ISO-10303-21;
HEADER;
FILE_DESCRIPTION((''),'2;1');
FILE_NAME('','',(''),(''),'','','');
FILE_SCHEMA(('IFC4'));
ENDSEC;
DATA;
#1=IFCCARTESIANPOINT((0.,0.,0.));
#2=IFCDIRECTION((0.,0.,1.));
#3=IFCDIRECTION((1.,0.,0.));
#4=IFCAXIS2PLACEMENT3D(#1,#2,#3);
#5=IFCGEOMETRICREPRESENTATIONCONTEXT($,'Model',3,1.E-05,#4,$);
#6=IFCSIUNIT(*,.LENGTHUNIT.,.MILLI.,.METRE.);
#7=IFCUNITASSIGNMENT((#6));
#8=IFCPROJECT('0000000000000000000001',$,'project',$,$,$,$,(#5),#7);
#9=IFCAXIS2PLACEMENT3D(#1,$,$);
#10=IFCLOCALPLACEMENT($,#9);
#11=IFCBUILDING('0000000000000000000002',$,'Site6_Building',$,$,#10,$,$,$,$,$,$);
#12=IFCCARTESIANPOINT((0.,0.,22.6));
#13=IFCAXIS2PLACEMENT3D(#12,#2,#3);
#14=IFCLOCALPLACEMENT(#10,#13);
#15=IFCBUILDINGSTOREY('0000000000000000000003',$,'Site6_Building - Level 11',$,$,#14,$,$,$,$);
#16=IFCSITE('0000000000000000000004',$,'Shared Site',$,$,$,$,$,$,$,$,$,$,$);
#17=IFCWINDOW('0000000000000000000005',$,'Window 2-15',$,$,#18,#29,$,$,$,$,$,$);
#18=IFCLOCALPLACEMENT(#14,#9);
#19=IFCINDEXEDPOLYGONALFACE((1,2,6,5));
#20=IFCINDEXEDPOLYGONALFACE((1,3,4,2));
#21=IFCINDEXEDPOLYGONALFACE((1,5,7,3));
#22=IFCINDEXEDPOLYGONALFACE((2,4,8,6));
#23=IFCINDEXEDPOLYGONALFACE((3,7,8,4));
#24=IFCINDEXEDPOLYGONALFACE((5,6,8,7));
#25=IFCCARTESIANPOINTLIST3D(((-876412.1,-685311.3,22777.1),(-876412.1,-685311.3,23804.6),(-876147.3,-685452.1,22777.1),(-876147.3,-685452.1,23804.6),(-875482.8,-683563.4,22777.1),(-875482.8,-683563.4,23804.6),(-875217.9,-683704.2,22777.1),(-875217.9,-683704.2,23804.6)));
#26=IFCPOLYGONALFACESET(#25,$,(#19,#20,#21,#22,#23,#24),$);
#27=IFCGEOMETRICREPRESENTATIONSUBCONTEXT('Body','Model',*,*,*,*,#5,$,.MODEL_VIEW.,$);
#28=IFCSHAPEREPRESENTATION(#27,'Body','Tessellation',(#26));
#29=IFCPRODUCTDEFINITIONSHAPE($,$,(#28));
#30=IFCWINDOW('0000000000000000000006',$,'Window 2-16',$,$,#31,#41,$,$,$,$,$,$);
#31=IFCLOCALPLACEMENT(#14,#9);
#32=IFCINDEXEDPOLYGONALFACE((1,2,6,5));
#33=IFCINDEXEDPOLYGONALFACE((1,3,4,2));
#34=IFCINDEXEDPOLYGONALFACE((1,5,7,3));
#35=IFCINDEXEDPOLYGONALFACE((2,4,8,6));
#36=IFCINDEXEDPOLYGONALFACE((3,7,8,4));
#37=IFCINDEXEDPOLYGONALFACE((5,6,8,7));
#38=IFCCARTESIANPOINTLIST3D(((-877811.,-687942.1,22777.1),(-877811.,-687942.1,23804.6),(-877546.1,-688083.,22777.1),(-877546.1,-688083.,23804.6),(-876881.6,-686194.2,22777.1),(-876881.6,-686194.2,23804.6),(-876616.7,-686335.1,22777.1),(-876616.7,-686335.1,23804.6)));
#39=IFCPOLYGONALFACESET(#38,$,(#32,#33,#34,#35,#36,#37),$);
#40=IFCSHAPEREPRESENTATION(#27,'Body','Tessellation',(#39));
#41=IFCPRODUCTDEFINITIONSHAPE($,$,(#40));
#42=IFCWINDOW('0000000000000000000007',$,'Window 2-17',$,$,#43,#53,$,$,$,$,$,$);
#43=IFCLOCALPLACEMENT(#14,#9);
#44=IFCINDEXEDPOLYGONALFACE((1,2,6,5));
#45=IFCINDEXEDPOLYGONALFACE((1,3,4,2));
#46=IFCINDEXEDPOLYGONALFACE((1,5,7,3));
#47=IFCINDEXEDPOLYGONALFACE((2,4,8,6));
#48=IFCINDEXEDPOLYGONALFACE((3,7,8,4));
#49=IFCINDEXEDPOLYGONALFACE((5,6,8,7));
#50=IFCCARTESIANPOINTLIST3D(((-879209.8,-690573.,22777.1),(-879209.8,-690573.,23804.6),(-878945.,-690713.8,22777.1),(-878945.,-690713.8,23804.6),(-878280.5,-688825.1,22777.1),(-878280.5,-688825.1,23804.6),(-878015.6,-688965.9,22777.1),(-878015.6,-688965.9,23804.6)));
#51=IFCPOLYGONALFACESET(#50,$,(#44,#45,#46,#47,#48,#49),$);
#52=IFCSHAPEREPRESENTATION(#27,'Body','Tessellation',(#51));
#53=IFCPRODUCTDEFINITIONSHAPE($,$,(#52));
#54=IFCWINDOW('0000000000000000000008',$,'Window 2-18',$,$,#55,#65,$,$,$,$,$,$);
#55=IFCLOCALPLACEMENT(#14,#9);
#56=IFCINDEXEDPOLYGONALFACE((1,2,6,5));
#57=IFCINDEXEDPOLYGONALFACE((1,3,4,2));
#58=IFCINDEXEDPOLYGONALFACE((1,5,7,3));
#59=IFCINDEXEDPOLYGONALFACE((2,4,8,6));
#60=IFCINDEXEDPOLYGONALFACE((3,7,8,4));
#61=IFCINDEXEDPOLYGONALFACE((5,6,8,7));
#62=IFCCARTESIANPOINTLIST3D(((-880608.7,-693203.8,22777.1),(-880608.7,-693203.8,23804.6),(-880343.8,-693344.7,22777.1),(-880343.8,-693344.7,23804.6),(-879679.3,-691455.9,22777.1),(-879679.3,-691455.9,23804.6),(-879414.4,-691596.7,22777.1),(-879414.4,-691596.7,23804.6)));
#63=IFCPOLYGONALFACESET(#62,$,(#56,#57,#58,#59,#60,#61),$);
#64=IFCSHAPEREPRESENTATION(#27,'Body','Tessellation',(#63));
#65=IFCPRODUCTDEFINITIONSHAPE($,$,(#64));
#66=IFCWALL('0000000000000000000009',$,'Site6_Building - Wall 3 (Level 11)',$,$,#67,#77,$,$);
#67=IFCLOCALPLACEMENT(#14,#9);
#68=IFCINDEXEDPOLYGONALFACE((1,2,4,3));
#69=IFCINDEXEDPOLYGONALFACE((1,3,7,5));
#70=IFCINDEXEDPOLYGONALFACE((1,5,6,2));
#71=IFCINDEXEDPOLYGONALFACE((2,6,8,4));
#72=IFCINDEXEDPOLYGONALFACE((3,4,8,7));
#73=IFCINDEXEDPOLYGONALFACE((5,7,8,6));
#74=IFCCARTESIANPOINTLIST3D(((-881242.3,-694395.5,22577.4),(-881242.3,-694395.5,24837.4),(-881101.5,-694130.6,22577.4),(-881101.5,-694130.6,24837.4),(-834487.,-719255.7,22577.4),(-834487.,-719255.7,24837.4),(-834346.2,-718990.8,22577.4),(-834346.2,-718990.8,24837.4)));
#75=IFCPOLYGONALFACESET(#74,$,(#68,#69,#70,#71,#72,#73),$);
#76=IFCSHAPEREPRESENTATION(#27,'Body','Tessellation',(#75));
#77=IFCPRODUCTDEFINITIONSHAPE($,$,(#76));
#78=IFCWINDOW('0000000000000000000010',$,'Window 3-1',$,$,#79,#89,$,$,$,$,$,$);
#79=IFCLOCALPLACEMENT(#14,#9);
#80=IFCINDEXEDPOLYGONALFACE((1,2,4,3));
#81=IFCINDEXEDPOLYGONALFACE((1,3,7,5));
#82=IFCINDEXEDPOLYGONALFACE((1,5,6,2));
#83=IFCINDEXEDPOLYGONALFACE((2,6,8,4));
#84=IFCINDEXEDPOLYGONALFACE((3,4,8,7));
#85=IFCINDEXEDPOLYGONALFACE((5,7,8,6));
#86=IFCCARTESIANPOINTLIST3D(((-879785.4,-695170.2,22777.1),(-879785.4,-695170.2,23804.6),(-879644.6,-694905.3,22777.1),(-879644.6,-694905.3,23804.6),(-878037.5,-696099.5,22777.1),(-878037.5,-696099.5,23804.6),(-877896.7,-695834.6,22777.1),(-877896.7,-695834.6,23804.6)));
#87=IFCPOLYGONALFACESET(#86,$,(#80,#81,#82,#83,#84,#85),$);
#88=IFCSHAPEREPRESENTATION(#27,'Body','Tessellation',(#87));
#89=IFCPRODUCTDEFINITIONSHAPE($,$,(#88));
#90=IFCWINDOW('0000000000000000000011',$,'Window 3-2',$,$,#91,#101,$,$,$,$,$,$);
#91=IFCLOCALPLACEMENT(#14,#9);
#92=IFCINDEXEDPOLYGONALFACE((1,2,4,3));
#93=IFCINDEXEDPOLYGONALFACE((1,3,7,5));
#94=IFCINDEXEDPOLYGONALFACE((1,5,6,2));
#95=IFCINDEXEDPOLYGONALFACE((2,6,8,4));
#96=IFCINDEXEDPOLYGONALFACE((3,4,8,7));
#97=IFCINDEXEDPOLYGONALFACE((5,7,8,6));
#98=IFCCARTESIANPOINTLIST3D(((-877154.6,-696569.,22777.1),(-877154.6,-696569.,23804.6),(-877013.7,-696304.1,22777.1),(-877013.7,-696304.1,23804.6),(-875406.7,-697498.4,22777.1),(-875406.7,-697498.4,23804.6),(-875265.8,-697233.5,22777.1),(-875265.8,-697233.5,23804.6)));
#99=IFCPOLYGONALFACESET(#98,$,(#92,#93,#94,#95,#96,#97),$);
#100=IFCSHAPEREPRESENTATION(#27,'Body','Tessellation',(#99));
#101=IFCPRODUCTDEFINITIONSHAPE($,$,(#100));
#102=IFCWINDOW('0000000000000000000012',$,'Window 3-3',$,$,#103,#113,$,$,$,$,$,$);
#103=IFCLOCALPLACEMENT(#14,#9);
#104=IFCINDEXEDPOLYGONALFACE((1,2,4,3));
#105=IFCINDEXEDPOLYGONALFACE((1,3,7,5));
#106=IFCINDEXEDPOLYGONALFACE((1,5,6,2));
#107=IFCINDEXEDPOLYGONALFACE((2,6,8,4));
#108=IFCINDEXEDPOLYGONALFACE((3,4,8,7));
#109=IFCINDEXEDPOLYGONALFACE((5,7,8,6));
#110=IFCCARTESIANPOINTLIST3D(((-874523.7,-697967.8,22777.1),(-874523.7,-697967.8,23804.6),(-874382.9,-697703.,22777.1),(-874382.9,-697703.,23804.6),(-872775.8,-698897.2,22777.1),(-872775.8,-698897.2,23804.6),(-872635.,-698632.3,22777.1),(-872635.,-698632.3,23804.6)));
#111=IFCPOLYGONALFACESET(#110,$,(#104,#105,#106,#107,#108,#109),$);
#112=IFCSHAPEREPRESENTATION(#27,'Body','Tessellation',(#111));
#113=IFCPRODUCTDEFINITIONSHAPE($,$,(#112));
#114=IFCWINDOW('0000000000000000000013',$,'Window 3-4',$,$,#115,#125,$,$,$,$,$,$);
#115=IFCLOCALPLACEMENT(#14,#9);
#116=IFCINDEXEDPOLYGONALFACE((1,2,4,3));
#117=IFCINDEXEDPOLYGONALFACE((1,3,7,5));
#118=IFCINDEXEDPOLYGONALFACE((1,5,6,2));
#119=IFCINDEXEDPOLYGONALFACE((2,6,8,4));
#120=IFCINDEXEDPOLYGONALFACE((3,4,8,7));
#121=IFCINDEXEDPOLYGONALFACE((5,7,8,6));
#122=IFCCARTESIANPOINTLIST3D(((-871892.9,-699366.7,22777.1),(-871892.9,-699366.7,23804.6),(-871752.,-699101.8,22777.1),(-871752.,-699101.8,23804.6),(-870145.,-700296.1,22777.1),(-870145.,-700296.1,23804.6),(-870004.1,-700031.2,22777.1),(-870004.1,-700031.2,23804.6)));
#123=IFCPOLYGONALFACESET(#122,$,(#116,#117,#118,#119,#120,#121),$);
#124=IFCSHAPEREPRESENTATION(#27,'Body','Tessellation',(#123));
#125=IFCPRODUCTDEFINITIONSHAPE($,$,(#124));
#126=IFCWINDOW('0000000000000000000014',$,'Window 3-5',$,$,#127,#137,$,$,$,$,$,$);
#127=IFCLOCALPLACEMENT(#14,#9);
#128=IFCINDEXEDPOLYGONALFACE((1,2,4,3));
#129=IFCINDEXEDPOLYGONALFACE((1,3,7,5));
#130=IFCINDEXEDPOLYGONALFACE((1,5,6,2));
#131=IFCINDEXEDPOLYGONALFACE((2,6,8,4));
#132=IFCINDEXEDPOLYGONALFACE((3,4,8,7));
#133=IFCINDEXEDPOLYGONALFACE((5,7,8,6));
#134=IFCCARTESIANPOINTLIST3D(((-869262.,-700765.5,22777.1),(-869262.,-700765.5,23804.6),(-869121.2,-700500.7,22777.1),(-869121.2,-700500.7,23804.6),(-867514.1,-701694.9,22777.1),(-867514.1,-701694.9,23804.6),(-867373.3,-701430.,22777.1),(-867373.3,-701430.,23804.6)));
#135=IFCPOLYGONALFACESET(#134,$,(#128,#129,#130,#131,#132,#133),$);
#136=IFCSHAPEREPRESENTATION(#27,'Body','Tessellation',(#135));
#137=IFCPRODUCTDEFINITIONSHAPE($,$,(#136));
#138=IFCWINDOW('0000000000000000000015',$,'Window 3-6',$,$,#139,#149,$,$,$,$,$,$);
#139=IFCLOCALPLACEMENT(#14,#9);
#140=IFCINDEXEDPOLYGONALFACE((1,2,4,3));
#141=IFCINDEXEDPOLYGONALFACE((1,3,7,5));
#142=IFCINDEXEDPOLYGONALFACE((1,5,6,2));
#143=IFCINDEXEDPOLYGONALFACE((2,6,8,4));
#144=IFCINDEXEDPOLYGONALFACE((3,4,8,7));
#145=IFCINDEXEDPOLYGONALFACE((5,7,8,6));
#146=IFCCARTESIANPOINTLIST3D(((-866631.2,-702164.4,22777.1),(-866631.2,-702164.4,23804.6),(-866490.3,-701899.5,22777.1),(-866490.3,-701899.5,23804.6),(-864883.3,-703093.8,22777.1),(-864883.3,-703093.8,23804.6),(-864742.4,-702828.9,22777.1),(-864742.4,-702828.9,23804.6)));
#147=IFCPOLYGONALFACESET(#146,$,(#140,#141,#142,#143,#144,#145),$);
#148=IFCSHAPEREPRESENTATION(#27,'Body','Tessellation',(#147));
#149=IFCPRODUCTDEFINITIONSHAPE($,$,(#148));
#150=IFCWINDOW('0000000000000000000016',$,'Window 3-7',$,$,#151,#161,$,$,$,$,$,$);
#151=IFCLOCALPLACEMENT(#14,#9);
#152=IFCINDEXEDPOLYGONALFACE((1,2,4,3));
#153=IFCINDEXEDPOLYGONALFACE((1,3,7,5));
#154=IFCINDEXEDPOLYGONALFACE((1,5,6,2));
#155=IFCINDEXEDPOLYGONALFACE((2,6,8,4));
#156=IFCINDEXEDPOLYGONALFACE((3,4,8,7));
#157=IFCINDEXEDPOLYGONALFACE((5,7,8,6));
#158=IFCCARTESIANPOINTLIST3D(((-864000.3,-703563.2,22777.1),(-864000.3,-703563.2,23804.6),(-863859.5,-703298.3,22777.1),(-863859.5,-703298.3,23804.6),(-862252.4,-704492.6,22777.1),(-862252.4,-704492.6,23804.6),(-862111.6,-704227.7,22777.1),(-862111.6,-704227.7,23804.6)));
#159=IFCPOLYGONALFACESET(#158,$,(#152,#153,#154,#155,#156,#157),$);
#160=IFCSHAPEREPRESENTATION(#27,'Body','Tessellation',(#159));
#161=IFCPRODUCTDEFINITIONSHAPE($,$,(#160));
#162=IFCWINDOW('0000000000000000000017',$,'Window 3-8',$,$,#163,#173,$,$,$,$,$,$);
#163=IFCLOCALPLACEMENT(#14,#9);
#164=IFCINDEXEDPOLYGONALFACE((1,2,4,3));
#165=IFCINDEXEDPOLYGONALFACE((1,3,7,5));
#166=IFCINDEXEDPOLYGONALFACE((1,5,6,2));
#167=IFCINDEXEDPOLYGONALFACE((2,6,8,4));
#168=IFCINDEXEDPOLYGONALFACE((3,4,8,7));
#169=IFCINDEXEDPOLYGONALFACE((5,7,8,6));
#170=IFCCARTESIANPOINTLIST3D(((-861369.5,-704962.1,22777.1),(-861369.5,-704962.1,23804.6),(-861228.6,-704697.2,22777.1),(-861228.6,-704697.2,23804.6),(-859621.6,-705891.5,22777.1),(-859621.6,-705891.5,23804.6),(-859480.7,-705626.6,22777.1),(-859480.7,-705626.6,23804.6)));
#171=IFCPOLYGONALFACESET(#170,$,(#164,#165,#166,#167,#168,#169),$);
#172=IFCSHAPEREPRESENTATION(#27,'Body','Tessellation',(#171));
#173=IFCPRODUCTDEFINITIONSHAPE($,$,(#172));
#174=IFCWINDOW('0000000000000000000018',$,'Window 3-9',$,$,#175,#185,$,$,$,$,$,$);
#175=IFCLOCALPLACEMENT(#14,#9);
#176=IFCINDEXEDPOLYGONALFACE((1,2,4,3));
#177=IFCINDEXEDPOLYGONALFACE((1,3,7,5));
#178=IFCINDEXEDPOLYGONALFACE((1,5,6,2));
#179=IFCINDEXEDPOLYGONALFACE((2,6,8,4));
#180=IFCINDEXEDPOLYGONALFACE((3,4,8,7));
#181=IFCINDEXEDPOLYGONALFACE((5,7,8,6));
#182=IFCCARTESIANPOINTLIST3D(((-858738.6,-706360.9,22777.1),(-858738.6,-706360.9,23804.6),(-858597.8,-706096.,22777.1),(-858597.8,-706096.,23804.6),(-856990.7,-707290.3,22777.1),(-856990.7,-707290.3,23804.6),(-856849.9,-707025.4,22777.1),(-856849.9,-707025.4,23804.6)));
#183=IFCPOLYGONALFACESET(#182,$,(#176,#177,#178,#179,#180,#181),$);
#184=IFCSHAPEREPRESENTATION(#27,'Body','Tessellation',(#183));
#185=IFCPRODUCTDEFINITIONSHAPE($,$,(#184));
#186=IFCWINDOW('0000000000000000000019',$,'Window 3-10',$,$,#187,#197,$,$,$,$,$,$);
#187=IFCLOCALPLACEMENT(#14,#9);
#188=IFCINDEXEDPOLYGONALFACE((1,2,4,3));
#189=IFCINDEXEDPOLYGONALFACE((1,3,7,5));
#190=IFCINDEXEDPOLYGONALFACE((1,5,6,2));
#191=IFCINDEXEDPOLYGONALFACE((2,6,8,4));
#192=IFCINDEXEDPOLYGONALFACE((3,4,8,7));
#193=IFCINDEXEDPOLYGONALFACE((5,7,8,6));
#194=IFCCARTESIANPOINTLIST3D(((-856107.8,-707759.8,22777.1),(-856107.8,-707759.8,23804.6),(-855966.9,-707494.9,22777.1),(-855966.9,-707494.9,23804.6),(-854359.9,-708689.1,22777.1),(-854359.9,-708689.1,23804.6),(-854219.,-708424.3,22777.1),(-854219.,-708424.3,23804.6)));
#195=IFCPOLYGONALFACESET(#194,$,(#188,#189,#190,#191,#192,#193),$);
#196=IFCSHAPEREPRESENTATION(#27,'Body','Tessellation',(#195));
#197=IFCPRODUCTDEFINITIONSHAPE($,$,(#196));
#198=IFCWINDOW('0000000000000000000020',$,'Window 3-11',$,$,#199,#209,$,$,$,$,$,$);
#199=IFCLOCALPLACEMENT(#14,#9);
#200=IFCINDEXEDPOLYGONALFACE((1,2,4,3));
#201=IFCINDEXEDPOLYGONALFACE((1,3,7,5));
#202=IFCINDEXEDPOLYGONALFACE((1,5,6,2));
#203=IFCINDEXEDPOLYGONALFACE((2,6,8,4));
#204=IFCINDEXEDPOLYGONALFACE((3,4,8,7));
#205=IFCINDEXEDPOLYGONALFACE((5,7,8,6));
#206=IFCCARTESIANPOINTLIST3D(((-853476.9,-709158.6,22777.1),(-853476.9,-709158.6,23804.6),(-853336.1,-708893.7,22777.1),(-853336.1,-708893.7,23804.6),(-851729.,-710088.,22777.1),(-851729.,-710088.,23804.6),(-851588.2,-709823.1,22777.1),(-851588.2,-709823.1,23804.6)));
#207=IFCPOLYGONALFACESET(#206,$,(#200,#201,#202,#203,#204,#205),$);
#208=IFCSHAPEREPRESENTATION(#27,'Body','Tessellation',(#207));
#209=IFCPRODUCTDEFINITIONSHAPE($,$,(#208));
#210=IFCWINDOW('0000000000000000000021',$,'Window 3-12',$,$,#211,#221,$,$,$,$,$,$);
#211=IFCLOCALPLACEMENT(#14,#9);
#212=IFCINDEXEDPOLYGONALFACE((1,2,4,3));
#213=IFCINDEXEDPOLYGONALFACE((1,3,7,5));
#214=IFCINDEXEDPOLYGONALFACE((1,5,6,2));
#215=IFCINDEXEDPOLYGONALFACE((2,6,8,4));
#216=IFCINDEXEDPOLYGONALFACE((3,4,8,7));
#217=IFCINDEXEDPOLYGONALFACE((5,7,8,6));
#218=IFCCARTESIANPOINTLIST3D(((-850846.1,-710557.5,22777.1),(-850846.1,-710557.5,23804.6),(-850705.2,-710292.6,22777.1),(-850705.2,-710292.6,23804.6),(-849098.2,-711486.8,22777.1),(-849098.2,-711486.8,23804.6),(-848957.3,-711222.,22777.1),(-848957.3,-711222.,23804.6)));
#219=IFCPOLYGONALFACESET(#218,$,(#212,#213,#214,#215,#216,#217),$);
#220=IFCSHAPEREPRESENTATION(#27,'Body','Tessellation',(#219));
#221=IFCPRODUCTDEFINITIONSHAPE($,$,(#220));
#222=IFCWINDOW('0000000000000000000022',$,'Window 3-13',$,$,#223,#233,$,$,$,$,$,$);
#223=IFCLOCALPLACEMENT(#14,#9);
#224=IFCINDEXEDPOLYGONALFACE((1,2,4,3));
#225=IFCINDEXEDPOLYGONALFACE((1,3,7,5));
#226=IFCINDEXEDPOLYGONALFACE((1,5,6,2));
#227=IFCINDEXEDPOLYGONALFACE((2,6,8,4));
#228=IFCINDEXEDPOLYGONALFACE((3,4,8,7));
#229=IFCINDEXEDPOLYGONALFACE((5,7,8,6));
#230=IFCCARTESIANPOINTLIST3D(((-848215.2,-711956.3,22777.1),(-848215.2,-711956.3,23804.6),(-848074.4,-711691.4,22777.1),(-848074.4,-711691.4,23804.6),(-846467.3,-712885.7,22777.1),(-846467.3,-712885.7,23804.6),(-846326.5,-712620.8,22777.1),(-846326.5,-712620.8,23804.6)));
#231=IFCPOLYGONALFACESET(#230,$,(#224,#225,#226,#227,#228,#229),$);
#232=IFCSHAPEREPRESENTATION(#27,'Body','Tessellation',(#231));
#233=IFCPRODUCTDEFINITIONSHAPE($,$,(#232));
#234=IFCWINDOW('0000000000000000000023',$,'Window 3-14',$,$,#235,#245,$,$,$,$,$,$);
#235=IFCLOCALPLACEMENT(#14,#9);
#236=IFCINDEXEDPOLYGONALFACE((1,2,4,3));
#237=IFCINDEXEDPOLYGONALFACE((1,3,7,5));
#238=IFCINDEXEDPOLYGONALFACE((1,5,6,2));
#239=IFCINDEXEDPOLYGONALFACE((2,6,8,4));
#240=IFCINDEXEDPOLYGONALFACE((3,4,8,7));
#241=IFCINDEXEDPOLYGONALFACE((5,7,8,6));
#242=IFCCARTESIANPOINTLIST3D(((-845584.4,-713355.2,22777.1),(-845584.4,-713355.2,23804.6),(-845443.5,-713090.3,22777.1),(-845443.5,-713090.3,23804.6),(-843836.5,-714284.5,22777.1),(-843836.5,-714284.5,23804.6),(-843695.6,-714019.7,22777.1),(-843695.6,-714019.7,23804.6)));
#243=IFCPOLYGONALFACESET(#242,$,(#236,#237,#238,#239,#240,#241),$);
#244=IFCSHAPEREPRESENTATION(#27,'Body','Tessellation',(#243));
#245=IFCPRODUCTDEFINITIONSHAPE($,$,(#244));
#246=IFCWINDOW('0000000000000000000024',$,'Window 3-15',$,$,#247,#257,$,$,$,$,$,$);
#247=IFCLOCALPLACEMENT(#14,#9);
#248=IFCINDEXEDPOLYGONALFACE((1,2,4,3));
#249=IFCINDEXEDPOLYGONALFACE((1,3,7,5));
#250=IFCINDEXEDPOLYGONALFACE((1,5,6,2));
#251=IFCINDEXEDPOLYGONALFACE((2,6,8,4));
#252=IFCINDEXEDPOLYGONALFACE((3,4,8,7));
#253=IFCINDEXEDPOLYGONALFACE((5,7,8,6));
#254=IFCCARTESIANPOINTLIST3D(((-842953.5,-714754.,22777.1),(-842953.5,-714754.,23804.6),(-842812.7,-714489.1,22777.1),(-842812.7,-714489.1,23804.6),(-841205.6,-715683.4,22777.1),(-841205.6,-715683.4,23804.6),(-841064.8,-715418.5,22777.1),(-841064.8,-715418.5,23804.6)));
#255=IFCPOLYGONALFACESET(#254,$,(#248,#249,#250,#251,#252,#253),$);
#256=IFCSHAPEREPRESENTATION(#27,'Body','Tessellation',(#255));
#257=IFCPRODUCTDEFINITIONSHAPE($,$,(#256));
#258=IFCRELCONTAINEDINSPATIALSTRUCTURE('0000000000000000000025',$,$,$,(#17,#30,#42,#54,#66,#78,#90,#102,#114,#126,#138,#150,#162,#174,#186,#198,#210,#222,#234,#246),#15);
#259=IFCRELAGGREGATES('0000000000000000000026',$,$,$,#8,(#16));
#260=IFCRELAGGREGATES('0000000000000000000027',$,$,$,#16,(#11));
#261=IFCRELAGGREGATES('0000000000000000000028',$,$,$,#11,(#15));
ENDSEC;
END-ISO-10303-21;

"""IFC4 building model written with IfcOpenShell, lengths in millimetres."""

from ifc_helpers import new_model, si_unit, frame, origin, origin_with_axes, place, context, subcontext, project, spatial, indexed_curve, outline, extrude, element, save


model = new_model("IFC4")

# Units and contexts
model_context = context("Model", 3, precision=1e-05, world=origin_with_axes())
body_context = subcontext(model_context, "Body", "Model", "MODEL_VIEW")
ifc_project = project(units=[si_unit("LENGTHUNIT", "METRE", prefix="MILLI")], contexts=[model_context])

# Site, building, storey
site = spatial("IfcSite", under=ifc_project, Name="Shared Site")
building_placement = place(None, origin())
building = spatial("IfcBuilding", under=site, at=building_placement, Name="Site6_Building")
storey_placement = place(building_placement, frame((0.0, 0.0, 22.6), z_axis=(0.0, 0.0, 1.0), x_axis=(1.0, 0.0, 0.0)))
storey = spatial("IfcBuildingStorey", under=building, at=storey_placement, Name="Site6_Building - Level 11")

# Windows
for number, where, z_axis, x_axis, name in (
    (1, (-875482.8, -683563.4, 22777.1), (0.0, 0.0, 1.0), (-0.469472, -0.882948, 0.0), "Window 2-15"),
    (2, (-876881.6, -686194.2, 22777.1), (0.0, 0.0, 1.0), (-0.469472, -0.882948, 0.0), "Window 2-16"),
    (3, (-878280.5, -688825.1, 22777.1), (0.0, 0.0, 1.0), (-0.469472, -0.882948, 0.0), "Window 2-17"),
    (4, (-879679.3, -691455.9, 22777.1), (0.0, 0.0, 1.0), (-0.469472, -0.882948, 0.0), "Window 2-18"),
):
    element("IfcWindow", number, at=place(storey_placement, frame(where, z_axis=z_axis, x_axis=x_axis)), inside=storey, Name=name, context=body_context, shape_type="SweptSolid", body=[
        extrude(outline(indexed_curve([(0.0, 0.0), (0.0, 300.0), (1979.6, 300.0), (1979.6, 0.0), (0.0, 0.0)], self_intersect=False)), origin_with_axes(), (0.0, 0.0, 1.0), 1027.5),
    ])

# Wall
wall_1_placement = place(storey_placement, frame((-881242.3, -694395.5, 22577.4), z_axis=(0.0, 0.0, 1.0), x_axis=(0.882948, -0.469472, 0.0)))
element("IfcWall", 5, at=wall_1_placement, inside=storey, Name="Site6_Building - Wall 3 (Level 11)", context=body_context, shape_type="SweptSolid", body=[
    extrude(outline(indexed_curve([(0.0, 0.0), (0.0, 300.0), (52953.6, 300.0), (52953.6, 0.0), (0.0, 0.0)], self_intersect=False)), origin_with_axes(), (0.0, 0.0, 1.0), 2260.0),
])

# Windows
for number, where, z_axis, x_axis, name in (
    (6, (-879785.4, -695170.2, 22777.1), (0.0, 0.0, 1.0), (0.882948, -0.469472, 0.0), "Window 3-1"),
    (7, (-877154.6, -696569.0, 22777.1), (0.0, 0.0, 1.0), (0.882948, -0.469472, 0.0), "Window 3-2"),
    (8, (-874523.7, -697967.8, 22777.1), (0.0, 0.0, 1.0), (0.882948, -0.469472, 0.0), "Window 3-3"),
    (9, (-871892.9, -699366.7, 22777.1), (0.0, 0.0, 1.0), (0.882948, -0.469472, 0.0), "Window 3-4"),
    (10, (-869262.0, -700765.5, 22777.1), (0.0, 0.0, 1.0), (0.882948, -0.469472, 0.0), "Window 3-5"),
    (11, (-866631.2, -702164.4, 22777.1), (0.0, 0.0, 1.0), (0.882948, -0.469472, 0.0), "Window 3-6"),
    (12, (-864000.3, -703563.2, 22777.1), (0.0, 0.0, 1.0), (0.882948, -0.469472, 0.0), "Window 3-7"),
    (13, (-861369.5, -704962.1, 22777.1), (0.0, 0.0, 1.0), (0.882948, -0.469472, 0.0), "Window 3-8"),
    (14, (-858738.6, -706360.9, 22777.1), (0.0, 0.0, 1.0), (0.882948, -0.469472, 0.0), "Window 3-9"),
    (15, (-856107.8, -707759.8, 22777.1), (0.0, 0.0, 1.0), (0.882948, -0.469472, 0.0), "Window 3-10"),
    (16, (-853476.9, -709158.6, 22777.1), (0.0, 0.0, 1.0), (0.882948, -0.469472, 0.0), "Window 3-11"),
    (17, (-850846.1, -710557.5, 22777.1), (0.0, 0.0, 1.0), (0.882948, -0.469472, 0.0), "Window 3-12"),
    (18, (-848215.2, -711956.3, 22777.1), (0.0, 0.0, 1.0), (0.882948, -0.469472, 0.0), "Window 3-13"),
    (19, (-845584.4, -713355.2, 22777.1), (0.0, 0.0, 1.0), (0.882948, -0.469472, 0.0), "Window 3-14"),
    (20, (-842953.5, -714754.0, 22777.1), (0.0, 0.0, 1.0), (0.882948, -0.469472, 0.0), "Window 3-15"),
):
    element("IfcWindow", number, at=place(storey_placement, frame(where, z_axis=z_axis, x_axis=x_axis)), inside=storey, Name=name, context=body_context, shape_type="SweptSolid", body=[
        extrude(outline(indexed_curve([(0.0, 0.0), (0.0, 300.0), (1979.6, 300.0), (1979.6, 0.0), (0.0, 0.0)], self_intersect=False)), origin_with_axes(), (0.0, 0.0, 1.0), 1027.5),
    ])

save(model, "model.ifc")
